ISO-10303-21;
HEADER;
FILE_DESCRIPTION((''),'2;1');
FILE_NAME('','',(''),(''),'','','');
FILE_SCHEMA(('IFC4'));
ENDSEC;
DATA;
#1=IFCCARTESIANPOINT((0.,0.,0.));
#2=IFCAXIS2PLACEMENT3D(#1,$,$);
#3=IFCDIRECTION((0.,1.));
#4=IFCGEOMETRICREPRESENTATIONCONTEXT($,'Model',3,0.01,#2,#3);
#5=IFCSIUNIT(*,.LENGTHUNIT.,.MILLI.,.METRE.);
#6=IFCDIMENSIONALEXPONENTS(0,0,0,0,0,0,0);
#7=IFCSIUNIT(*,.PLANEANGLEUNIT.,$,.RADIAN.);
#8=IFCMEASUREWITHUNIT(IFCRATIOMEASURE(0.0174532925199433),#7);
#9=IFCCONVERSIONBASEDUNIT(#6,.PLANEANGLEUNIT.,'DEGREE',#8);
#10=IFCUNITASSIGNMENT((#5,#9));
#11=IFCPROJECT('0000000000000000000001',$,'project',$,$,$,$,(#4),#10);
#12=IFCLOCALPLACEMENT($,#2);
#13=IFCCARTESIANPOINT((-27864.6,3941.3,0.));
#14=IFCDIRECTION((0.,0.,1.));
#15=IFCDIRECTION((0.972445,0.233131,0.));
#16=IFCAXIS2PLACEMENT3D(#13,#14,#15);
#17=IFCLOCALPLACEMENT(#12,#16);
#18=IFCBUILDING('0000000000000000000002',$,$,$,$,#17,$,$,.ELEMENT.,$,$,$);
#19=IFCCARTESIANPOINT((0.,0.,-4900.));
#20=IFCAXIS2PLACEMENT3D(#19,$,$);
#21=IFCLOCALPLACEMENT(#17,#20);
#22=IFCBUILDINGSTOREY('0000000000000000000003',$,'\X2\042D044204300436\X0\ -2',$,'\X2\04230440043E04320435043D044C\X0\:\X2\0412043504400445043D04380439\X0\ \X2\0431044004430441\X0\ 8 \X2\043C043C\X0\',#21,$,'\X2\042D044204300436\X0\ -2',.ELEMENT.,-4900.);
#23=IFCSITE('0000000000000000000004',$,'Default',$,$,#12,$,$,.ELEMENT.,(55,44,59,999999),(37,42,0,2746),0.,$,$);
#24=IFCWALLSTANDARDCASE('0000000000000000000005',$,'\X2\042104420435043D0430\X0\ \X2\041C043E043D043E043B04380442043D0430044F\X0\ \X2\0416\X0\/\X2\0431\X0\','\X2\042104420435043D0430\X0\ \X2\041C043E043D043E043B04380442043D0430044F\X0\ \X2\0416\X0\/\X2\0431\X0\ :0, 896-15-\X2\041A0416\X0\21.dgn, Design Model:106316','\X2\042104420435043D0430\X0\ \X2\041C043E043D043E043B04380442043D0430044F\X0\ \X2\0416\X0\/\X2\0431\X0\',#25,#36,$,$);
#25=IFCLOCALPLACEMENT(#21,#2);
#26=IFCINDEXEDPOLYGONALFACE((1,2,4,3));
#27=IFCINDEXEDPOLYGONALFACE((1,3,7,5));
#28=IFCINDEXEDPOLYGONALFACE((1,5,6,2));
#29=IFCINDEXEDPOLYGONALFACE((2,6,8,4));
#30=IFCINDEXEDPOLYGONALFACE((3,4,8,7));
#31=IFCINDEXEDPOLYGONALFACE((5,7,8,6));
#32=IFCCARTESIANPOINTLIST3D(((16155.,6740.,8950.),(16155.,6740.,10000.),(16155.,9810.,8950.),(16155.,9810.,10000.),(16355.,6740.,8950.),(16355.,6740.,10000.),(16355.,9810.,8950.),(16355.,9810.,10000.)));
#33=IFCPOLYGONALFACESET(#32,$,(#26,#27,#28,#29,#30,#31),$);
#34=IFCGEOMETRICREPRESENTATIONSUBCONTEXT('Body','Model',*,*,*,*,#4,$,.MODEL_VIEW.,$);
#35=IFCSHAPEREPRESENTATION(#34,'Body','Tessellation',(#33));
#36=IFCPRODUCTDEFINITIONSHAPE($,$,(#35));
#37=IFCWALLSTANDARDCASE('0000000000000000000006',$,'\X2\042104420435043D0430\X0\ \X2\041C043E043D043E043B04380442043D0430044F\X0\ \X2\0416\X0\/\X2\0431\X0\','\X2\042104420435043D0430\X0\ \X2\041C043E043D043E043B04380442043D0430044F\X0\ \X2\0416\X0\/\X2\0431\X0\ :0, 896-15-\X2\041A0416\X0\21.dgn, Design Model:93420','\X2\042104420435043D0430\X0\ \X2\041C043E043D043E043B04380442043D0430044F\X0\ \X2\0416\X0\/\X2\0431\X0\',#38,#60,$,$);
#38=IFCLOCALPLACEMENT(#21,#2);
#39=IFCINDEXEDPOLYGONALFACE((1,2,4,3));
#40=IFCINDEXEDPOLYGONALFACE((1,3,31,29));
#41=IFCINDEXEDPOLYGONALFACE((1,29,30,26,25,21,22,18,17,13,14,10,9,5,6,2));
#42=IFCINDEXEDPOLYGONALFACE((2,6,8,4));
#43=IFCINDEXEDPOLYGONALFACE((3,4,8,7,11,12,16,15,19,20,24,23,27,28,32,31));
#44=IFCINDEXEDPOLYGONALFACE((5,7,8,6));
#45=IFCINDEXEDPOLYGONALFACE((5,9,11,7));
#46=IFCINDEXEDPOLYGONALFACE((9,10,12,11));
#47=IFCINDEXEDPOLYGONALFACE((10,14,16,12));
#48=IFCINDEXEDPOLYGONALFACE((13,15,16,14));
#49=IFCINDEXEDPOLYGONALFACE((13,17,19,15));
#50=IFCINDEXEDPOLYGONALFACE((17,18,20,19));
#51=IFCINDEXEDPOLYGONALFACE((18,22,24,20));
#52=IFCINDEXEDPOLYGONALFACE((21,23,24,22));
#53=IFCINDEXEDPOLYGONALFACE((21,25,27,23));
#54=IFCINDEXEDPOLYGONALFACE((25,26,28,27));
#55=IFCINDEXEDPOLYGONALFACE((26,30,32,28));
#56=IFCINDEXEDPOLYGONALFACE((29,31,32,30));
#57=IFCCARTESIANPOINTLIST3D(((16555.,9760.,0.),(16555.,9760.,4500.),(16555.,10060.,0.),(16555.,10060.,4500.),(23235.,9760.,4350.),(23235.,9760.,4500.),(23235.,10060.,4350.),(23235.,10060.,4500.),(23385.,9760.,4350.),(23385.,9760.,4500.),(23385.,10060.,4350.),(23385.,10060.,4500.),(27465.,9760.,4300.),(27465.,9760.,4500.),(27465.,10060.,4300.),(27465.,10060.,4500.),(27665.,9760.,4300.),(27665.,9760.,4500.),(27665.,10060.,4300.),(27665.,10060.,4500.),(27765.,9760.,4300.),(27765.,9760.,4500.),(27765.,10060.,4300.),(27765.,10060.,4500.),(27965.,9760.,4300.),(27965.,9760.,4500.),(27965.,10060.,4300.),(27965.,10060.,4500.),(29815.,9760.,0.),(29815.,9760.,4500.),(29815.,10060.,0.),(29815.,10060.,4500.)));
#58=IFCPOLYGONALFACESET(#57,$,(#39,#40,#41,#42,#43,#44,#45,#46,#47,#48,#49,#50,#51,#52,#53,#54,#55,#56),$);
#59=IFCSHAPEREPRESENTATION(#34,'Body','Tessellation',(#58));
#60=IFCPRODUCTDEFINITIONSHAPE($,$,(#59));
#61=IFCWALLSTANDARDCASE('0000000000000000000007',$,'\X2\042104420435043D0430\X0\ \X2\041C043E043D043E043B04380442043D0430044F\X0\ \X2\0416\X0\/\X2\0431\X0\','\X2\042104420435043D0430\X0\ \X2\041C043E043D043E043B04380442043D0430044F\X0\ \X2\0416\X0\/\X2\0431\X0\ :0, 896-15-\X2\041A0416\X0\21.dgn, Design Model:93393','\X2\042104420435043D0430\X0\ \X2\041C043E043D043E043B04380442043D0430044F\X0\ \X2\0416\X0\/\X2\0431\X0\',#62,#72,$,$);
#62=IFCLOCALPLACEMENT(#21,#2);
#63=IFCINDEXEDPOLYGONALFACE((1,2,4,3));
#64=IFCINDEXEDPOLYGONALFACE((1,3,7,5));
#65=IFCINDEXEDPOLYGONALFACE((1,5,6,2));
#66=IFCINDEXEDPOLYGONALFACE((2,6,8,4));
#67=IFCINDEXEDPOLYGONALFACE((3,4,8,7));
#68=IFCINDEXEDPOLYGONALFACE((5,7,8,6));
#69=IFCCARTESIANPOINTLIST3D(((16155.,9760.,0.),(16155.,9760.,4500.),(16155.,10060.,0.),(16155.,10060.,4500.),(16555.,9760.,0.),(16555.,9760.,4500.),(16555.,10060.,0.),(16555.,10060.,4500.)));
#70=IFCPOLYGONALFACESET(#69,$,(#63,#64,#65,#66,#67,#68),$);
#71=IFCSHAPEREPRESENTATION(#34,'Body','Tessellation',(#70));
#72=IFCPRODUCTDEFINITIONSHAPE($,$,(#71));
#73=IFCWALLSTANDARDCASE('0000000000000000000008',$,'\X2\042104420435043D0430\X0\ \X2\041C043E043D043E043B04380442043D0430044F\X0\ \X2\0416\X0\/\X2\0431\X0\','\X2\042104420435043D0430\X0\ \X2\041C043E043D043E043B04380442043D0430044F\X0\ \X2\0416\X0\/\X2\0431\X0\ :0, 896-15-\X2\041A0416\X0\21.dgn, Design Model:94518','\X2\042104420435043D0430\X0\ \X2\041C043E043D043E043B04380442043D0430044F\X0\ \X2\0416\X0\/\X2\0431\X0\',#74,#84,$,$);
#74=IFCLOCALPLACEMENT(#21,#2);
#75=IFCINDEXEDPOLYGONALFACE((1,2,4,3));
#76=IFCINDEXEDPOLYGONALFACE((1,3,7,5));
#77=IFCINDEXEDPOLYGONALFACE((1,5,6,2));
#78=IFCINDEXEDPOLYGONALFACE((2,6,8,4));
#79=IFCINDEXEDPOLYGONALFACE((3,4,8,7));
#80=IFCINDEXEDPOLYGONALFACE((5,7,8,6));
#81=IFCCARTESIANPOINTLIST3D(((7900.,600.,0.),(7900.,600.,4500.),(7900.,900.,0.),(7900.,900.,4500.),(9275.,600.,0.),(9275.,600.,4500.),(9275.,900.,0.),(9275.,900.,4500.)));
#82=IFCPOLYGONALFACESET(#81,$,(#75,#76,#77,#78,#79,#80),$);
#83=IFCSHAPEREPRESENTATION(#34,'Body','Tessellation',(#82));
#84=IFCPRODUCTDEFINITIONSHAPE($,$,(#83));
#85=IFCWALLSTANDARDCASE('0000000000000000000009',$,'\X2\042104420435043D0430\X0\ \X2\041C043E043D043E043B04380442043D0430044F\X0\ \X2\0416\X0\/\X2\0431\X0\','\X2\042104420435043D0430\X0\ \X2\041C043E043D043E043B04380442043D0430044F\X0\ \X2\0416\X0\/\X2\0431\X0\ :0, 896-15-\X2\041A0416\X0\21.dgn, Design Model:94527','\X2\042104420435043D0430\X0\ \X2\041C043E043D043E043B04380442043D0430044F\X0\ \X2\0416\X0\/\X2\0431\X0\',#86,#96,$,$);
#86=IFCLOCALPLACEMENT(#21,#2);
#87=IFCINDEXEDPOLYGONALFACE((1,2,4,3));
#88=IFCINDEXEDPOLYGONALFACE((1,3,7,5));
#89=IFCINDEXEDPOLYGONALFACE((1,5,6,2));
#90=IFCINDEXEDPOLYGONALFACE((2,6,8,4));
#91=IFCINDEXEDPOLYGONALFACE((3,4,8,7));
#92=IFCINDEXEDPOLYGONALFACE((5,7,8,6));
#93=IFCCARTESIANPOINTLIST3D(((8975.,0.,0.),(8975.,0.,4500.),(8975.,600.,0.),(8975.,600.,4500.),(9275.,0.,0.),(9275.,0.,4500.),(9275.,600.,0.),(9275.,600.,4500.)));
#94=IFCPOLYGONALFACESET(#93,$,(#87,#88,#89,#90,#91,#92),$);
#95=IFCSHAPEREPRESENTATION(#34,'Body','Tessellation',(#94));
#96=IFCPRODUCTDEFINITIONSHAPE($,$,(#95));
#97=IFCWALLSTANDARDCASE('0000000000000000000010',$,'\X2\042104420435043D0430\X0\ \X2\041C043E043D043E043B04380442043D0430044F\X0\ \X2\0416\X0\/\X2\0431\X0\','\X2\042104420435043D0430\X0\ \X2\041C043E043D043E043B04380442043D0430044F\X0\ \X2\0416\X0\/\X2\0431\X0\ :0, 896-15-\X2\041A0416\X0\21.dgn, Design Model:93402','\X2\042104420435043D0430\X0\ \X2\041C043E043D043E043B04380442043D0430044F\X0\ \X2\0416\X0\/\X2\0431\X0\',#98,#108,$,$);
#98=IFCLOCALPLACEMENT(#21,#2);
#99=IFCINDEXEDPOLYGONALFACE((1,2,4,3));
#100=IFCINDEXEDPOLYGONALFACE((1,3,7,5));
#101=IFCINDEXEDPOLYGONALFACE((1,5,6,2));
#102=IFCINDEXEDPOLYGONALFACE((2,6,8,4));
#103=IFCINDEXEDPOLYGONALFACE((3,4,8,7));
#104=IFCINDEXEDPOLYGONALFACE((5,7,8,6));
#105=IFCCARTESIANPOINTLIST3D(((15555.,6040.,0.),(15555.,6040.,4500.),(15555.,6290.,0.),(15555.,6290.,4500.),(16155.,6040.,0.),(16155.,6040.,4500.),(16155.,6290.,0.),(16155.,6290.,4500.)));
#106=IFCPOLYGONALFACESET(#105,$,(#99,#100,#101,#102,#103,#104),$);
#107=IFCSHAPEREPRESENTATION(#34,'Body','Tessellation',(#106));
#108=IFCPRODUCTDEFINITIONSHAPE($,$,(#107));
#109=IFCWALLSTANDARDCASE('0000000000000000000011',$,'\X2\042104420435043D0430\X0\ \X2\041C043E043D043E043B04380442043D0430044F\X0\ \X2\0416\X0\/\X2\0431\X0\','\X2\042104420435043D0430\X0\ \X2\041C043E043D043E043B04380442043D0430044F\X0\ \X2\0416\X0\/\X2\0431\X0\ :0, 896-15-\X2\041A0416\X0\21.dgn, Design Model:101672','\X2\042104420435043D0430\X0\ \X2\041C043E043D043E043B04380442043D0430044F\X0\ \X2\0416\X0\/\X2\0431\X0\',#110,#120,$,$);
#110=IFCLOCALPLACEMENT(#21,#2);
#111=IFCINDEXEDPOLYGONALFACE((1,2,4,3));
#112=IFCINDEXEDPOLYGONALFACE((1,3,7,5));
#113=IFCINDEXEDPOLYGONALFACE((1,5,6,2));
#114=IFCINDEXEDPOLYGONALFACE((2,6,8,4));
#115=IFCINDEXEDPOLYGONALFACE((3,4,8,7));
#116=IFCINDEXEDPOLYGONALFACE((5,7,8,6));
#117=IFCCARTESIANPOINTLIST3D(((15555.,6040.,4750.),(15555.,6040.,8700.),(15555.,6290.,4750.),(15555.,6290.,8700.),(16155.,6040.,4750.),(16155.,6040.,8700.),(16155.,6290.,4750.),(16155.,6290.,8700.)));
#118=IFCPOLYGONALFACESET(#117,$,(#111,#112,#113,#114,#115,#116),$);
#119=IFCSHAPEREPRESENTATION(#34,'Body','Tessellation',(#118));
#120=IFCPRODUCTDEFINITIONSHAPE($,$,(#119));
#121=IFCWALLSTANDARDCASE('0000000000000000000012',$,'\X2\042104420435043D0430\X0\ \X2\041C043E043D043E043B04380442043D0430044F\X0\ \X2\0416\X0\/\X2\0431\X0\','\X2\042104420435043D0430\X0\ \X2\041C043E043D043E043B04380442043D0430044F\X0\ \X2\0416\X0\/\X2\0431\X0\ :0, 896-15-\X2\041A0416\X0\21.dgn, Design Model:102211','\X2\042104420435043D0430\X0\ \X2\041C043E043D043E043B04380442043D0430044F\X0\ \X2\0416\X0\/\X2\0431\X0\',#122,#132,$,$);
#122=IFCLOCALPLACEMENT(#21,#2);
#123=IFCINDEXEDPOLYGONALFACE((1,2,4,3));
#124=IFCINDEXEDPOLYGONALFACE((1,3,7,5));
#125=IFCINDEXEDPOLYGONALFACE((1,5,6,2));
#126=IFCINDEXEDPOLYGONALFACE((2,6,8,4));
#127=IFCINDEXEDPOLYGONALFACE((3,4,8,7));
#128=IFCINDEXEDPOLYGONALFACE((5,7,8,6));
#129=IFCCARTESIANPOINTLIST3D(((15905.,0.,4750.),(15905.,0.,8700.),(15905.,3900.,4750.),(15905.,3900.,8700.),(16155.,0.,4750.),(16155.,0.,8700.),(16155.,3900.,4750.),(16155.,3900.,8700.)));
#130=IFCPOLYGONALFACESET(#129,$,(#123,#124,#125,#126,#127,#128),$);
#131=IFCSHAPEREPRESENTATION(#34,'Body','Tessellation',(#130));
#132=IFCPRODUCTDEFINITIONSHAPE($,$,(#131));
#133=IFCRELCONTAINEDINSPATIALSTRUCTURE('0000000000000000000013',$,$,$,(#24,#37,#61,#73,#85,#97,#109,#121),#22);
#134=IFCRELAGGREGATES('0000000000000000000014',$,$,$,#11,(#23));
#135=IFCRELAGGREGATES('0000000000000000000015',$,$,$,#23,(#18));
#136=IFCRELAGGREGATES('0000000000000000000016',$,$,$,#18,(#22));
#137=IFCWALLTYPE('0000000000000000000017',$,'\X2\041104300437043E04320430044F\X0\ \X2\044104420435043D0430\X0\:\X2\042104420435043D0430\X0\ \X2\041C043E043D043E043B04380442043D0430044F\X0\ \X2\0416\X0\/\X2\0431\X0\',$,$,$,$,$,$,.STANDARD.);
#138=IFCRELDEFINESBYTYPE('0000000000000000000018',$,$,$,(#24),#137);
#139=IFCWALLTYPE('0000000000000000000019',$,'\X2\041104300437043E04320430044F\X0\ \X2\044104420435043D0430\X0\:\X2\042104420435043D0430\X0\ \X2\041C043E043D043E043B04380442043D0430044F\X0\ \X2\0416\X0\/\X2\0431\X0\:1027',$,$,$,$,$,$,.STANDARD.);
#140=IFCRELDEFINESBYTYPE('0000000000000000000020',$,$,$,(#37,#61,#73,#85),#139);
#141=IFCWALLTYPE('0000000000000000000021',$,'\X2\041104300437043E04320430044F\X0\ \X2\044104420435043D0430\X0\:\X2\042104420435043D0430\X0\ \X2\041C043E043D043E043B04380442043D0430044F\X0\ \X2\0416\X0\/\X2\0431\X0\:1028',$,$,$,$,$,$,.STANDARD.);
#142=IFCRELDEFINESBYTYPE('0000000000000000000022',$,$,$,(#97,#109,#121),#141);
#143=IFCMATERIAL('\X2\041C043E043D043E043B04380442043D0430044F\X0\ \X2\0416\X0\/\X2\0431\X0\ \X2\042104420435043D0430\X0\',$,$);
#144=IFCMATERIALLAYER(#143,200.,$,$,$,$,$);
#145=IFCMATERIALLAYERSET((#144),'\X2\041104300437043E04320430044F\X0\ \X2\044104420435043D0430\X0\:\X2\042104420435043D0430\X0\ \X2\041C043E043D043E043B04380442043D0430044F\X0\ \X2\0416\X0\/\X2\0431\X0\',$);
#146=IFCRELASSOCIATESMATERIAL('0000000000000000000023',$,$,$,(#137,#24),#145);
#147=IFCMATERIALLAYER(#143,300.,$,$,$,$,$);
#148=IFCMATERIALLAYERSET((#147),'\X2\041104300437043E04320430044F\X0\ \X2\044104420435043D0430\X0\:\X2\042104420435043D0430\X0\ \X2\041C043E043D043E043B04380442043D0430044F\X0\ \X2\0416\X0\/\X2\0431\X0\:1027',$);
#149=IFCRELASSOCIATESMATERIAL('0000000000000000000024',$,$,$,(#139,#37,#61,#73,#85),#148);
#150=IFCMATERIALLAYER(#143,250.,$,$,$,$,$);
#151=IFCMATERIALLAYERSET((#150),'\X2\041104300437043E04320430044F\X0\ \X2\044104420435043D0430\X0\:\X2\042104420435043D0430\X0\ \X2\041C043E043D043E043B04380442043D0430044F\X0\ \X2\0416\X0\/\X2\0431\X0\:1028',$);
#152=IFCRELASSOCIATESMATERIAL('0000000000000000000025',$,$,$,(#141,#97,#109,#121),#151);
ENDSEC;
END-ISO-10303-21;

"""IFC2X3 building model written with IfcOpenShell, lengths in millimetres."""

from ifc_helpers import new_model, entity, si_unit, converted_unit, direction, frame, frame_2d, origin, origin_2d_with_axis, place, context, subcontext, project, spatial, rectangle, extrude, material, layer, layer_set, layer_usage, type_object, element, save


model = new_model("IFC2X3")

# Units and contexts
model_context = context("Model", 3, precision=0.01, world=origin(), true_north=direction((0.0, 1.0)))
body_context = subcontext(model_context, "Body", "Model", "MODEL_VIEW")
ifc_project = project(units=[si_unit("LENGTHUNIT", "METRE", prefix="MILLI"), converted_unit("PLANEANGLEUNIT", "DEGREE", entity("IfcRatioMeasure", 0.0174532925199433), si_unit("PLANEANGLEUNIT", "RADIAN"), dimensions=[0, 0, 0, 0, 0, 0, 0])], contexts=[model_context])

# Site, building, storey
site_placement = place(None, origin())
site = spatial("IfcSite", under=ifc_project, at=site_placement, Name="Default", CompositionType="ELEMENT", RefLatitude=(55, 44, 59, 999999), RefLongitude=(37, 42, 0, 2746), RefElevation=0.0)
building_placement = place(site_placement, frame((-27864.6, 3941.3, 0.0), z_axis=(0.0, 0.0, 1.0), x_axis=(0.972445, 0.233131, 0.0)))
building = spatial("IfcBuilding", under=site, at=building_placement, CompositionType="ELEMENT")
storey_placement = place(building_placement, frame((0.0, 0.0, -4900.0)))
storey = spatial("IfcBuildingStorey", under=building, at=storey_placement, Name="Этаж -2", ObjectType="Уровень:Верхний брус 8 мм", LongName="Этаж -2", CompositionType="ELEMENT", Elevation=-4900.0)

# Shared definitions
ifc_material = material(Name="Монолитная Ж/б Стена")
ifc_layer_1 = layer(ifc_material, 200.0)
ifc_layer_set_1 = layer_set([ifc_layer_1], Name="Базовая стена:Стена Монолитная Ж/б")
wall_type_1 = type_object("IfcWallType", Name="Базовая стена:Стена Монолитная Ж/б", PredefinedType="STANDARD", material=ifc_layer_set_1)

# Wall
ifc_layer_usage_1 = layer_usage(ifc_layer_set_1, "AXIS2", "NEGATIVE", 100.0)
wall_1_placement = place(storey_placement, frame((16255.0, 9810.0, 8950.0), z_axis=(0.0, 0.0, 1.0), x_axis=(0.0, -1.0, 0.0)))
element("IfcWallStandardCase", 1, at=wall_1_placement, inside=storey, type_object=wall_type_1, material=ifc_layer_usage_1, Name="Стена Монолитная Ж/б", Description="Стена Монолитная Ж/б :0, 896-15-КЖ21.dgn, Design Model:106316", ObjectType="Стена Монолитная Ж/б", context=body_context, shape_type="SweptSolid", body=[
    extrude(rectangle(XDim=3070.0, YDim=200.0, at=frame_2d((1535.0, 0.0), x_axis=(-1.0, 0.0))), origin(), (0.0, 0.0, 1.0), 1050.0),
])

# Wall, openings
ifc_layer_2 = layer(ifc_material, 300.0)
ifc_layer_set_2 = layer_set([ifc_layer_2], Name="Базовая стена:Стена Монолитная Ж/б:1027")
ifc_layer_usage_2 = layer_usage(ifc_layer_set_2, "AXIS2", "NEGATIVE", 150.0)
wall_type_2 = type_object("IfcWallType", Name="Базовая стена:Стена Монолитная Ж/б:1027", PredefinedType="STANDARD", material=ifc_layer_set_2)
wall_2_placement = place(storey_placement, frame((16555.0, 9910.0, 0.0)))
wall_2 = element("IfcWallStandardCase", 2, at=wall_2_placement, inside=storey, type_object=wall_type_2, material=ifc_layer_usage_2, Name="Стена Монолитная Ж/б", Description="Стена Монолитная Ж/б :0, 896-15-КЖ21.dgn, Design Model:93420", ObjectType="Стена Монолитная Ж/б", context=body_context, shape_type="SweptSolid", body=[
    extrude(rectangle(XDim=13260.0, YDim=300.0, at=frame_2d((6630.0, 0.0), x_axis=(-1.0, 0.0))), origin(), (0.0, 0.0, 1.0), 4500.0),
])
opening_1_placement = place(wall_2_placement, origin())
element("IfcOpeningElement", 3, at=opening_1_placement, cuts=wall_2, ObjectType="Opening", context=body_context, shape_type="SweptSolid", body=[
    extrude(rectangle(XDim=150.0, YDim=150.0, at=origin_2d_with_axis()), frame((6755.0, -150.0, 4425.0), z_axis=(0.0, 1.0, 0.0), x_axis=(0.0, 0.0, -1.0)), (0.0, 0.0, 1.0), 300.0),
])
opening_2_placement = place(wall_2_placement, origin())
element("IfcOpeningElement", 4, at=opening_2_placement, cuts=wall_2, ObjectType="Opening", context=body_context, shape_type="SweptSolid", body=[
    extrude(rectangle(XDim=200.0, YDim=200.0, at=origin_2d_with_axis()), frame((11010.0, -150.0, 4400.0), z_axis=(0.0, 1.0, 0.0), x_axis=(0.0, 0.0, -1.0)), (0.0, 0.0, 1.0), 300.0),
])
opening_3_placement = place(wall_2_placement, origin())
element("IfcOpeningElement", 5, at=opening_3_placement, cuts=wall_2, ObjectType="Opening", context=body_context, shape_type="SweptSolid", body=[
    extrude(rectangle(XDim=200.0, YDim=200.0, at=origin_2d_with_axis()), frame((11310.0, -150.0, 4400.0), z_axis=(0.0, 1.0, 0.0), x_axis=(0.0, 0.0, -1.0)), (0.0, 0.0, 1.0), 300.0),
])

# Walls
ifc_layer_usage_3 = layer_usage(ifc_layer_set_2, "AXIS2", "NEGATIVE", 150.0)
wall_3_placement = place(storey_placement, frame((16155.0, 9910.0, 0.0)))
element("IfcWallStandardCase", 6, at=wall_3_placement, inside=storey, type_object=wall_type_2, material=ifc_layer_usage_3, Name="Стена Монолитная Ж/б", Description="Стена Монолитная Ж/б :0, 896-15-КЖ21.dgn, Design Model:93393", ObjectType="Стена Монолитная Ж/б", context=body_context, shape_type="SweptSolid", body=[
    extrude(rectangle(XDim=400.0, YDim=300.0, at=frame_2d((200.0, 0.0), x_axis=(-1.0, 0.0))), origin(), (0.0, 0.0, 1.0), 4500.0),
])
ifc_layer_usage_4 = layer_usage(ifc_layer_set_2, "AXIS2", "NEGATIVE", 150.0)
wall_4_placement = place(storey_placement, frame((9275.0, 750.0, 0.0), z_axis=(0.0, 0.0, 1.0), x_axis=(-1.0, 0.0, 0.0)))
element("IfcWallStandardCase", 7, at=wall_4_placement, inside=storey, type_object=wall_type_2, material=ifc_layer_usage_4, Name="Стена Монолитная Ж/б", Description="Стена Монолитная Ж/б :0, 896-15-КЖ21.dgn, Design Model:94518", ObjectType="Стена Монолитная Ж/б", context=body_context, shape_type="SweptSolid", body=[
    extrude(rectangle(XDim=1375.0, YDim=300.0, at=frame_2d((687.5, 0.0), x_axis=(-1.0, 0.0))), origin(), (0.0, 0.0, 1.0), 4500.0),
])
ifc_layer_usage_5 = layer_usage(ifc_layer_set_2, "AXIS2", "NEGATIVE", 150.0)
wall_5_placement = place(storey_placement, frame((9125.0, 0.0, 0.0), z_axis=(0.0, 0.0, 1.0), x_axis=(0.0, 1.0, 0.0)))
element("IfcWallStandardCase", 8, at=wall_5_placement, inside=storey, type_object=wall_type_2, material=ifc_layer_usage_5, Name="Стена Монолитная Ж/б", Description="Стена Монолитная Ж/б :0, 896-15-КЖ21.dgn, Design Model:94527", ObjectType="Стена Монолитная Ж/б", context=body_context, shape_type="SweptSolid", body=[
    extrude(rectangle(XDim=600.0, YDim=300.0, at=frame_2d((300.0, 0.0), x_axis=(-1.0, 0.0))), origin(), (0.0, 0.0, 1.0), 4500.0),
])
ifc_layer_3 = layer(ifc_material, 250.0)
ifc_layer_set_3 = layer_set([ifc_layer_3], Name="Базовая стена:Стена Монолитная Ж/б:1028")
ifc_layer_usage_6 = layer_usage(ifc_layer_set_3, "AXIS2", "NEGATIVE", 125.0)
wall_type_3 = type_object("IfcWallType", Name="Базовая стена:Стена Монолитная Ж/б:1028", PredefinedType="STANDARD", material=ifc_layer_set_3)
wall_6_placement = place(storey_placement, frame((16155.0, 6165.0, 0.0), z_axis=(0.0, 0.0, 1.0), x_axis=(-1.0, 0.0, 0.0)))
element("IfcWallStandardCase", 9, at=wall_6_placement, inside=storey, type_object=wall_type_3, material=ifc_layer_usage_6, Name="Стена Монолитная Ж/б", Description="Стена Монолитная Ж/б :0, 896-15-КЖ21.dgn, Design Model:93402", ObjectType="Стена Монолитная Ж/б", context=body_context, shape_type="SweptSolid", body=[
    extrude(rectangle(XDim=600.0, YDim=250.0, at=frame_2d((300.0, 0.0), x_axis=(-1.0, 0.0))), origin(), (0.0, 0.0, 1.0), 4500.0),
])
ifc_layer_usage_7 = layer_usage(ifc_layer_set_3, "AXIS2", "NEGATIVE", 125.0)
wall_7_placement = place(storey_placement, frame((16155.0, 6165.0, 4750.0), z_axis=(0.0, 0.0, 1.0), x_axis=(-1.0, 0.0, 0.0)))
element("IfcWallStandardCase", 10, at=wall_7_placement, inside=storey, type_object=wall_type_3, material=ifc_layer_usage_7, Name="Стена Монолитная Ж/б", Description="Стена Монолитная Ж/б :0, 896-15-КЖ21.dgn, Design Model:101672", ObjectType="Стена Монолитная Ж/б", context=body_context, shape_type="SweptSolid", body=[
    extrude(rectangle(XDim=600.0, YDim=250.0, at=frame_2d((300.0, 0.0), x_axis=(-1.0, 0.0))), origin(), (0.0, 0.0, 1.0), 3950.0),
])
ifc_layer_usage_8 = layer_usage(ifc_layer_set_3, "AXIS2", "NEGATIVE", 125.0)
wall_8_placement = place(storey_placement, frame((16030.0, 3900.0, 4750.0), z_axis=(0.0, 0.0, 1.0), x_axis=(0.0, -1.0, 0.0)))
element("IfcWallStandardCase", 11, at=wall_8_placement, inside=storey, type_object=wall_type_3, material=ifc_layer_usage_8, Name="Стена Монолитная Ж/б", Description="Стена Монолитная Ж/б :0, 896-15-КЖ21.dgn, Design Model:102211", ObjectType="Стена Монолитная Ж/б", context=body_context, shape_type="SweptSolid", body=[
    extrude(rectangle(XDim=3900.0, YDim=250.0, at=frame_2d((1950.0, 0.0), x_axis=(-1.0, 0.0))), origin(), (0.0, 0.0, 1.0), 3950.0),
])

save(model, "model.ifc")
